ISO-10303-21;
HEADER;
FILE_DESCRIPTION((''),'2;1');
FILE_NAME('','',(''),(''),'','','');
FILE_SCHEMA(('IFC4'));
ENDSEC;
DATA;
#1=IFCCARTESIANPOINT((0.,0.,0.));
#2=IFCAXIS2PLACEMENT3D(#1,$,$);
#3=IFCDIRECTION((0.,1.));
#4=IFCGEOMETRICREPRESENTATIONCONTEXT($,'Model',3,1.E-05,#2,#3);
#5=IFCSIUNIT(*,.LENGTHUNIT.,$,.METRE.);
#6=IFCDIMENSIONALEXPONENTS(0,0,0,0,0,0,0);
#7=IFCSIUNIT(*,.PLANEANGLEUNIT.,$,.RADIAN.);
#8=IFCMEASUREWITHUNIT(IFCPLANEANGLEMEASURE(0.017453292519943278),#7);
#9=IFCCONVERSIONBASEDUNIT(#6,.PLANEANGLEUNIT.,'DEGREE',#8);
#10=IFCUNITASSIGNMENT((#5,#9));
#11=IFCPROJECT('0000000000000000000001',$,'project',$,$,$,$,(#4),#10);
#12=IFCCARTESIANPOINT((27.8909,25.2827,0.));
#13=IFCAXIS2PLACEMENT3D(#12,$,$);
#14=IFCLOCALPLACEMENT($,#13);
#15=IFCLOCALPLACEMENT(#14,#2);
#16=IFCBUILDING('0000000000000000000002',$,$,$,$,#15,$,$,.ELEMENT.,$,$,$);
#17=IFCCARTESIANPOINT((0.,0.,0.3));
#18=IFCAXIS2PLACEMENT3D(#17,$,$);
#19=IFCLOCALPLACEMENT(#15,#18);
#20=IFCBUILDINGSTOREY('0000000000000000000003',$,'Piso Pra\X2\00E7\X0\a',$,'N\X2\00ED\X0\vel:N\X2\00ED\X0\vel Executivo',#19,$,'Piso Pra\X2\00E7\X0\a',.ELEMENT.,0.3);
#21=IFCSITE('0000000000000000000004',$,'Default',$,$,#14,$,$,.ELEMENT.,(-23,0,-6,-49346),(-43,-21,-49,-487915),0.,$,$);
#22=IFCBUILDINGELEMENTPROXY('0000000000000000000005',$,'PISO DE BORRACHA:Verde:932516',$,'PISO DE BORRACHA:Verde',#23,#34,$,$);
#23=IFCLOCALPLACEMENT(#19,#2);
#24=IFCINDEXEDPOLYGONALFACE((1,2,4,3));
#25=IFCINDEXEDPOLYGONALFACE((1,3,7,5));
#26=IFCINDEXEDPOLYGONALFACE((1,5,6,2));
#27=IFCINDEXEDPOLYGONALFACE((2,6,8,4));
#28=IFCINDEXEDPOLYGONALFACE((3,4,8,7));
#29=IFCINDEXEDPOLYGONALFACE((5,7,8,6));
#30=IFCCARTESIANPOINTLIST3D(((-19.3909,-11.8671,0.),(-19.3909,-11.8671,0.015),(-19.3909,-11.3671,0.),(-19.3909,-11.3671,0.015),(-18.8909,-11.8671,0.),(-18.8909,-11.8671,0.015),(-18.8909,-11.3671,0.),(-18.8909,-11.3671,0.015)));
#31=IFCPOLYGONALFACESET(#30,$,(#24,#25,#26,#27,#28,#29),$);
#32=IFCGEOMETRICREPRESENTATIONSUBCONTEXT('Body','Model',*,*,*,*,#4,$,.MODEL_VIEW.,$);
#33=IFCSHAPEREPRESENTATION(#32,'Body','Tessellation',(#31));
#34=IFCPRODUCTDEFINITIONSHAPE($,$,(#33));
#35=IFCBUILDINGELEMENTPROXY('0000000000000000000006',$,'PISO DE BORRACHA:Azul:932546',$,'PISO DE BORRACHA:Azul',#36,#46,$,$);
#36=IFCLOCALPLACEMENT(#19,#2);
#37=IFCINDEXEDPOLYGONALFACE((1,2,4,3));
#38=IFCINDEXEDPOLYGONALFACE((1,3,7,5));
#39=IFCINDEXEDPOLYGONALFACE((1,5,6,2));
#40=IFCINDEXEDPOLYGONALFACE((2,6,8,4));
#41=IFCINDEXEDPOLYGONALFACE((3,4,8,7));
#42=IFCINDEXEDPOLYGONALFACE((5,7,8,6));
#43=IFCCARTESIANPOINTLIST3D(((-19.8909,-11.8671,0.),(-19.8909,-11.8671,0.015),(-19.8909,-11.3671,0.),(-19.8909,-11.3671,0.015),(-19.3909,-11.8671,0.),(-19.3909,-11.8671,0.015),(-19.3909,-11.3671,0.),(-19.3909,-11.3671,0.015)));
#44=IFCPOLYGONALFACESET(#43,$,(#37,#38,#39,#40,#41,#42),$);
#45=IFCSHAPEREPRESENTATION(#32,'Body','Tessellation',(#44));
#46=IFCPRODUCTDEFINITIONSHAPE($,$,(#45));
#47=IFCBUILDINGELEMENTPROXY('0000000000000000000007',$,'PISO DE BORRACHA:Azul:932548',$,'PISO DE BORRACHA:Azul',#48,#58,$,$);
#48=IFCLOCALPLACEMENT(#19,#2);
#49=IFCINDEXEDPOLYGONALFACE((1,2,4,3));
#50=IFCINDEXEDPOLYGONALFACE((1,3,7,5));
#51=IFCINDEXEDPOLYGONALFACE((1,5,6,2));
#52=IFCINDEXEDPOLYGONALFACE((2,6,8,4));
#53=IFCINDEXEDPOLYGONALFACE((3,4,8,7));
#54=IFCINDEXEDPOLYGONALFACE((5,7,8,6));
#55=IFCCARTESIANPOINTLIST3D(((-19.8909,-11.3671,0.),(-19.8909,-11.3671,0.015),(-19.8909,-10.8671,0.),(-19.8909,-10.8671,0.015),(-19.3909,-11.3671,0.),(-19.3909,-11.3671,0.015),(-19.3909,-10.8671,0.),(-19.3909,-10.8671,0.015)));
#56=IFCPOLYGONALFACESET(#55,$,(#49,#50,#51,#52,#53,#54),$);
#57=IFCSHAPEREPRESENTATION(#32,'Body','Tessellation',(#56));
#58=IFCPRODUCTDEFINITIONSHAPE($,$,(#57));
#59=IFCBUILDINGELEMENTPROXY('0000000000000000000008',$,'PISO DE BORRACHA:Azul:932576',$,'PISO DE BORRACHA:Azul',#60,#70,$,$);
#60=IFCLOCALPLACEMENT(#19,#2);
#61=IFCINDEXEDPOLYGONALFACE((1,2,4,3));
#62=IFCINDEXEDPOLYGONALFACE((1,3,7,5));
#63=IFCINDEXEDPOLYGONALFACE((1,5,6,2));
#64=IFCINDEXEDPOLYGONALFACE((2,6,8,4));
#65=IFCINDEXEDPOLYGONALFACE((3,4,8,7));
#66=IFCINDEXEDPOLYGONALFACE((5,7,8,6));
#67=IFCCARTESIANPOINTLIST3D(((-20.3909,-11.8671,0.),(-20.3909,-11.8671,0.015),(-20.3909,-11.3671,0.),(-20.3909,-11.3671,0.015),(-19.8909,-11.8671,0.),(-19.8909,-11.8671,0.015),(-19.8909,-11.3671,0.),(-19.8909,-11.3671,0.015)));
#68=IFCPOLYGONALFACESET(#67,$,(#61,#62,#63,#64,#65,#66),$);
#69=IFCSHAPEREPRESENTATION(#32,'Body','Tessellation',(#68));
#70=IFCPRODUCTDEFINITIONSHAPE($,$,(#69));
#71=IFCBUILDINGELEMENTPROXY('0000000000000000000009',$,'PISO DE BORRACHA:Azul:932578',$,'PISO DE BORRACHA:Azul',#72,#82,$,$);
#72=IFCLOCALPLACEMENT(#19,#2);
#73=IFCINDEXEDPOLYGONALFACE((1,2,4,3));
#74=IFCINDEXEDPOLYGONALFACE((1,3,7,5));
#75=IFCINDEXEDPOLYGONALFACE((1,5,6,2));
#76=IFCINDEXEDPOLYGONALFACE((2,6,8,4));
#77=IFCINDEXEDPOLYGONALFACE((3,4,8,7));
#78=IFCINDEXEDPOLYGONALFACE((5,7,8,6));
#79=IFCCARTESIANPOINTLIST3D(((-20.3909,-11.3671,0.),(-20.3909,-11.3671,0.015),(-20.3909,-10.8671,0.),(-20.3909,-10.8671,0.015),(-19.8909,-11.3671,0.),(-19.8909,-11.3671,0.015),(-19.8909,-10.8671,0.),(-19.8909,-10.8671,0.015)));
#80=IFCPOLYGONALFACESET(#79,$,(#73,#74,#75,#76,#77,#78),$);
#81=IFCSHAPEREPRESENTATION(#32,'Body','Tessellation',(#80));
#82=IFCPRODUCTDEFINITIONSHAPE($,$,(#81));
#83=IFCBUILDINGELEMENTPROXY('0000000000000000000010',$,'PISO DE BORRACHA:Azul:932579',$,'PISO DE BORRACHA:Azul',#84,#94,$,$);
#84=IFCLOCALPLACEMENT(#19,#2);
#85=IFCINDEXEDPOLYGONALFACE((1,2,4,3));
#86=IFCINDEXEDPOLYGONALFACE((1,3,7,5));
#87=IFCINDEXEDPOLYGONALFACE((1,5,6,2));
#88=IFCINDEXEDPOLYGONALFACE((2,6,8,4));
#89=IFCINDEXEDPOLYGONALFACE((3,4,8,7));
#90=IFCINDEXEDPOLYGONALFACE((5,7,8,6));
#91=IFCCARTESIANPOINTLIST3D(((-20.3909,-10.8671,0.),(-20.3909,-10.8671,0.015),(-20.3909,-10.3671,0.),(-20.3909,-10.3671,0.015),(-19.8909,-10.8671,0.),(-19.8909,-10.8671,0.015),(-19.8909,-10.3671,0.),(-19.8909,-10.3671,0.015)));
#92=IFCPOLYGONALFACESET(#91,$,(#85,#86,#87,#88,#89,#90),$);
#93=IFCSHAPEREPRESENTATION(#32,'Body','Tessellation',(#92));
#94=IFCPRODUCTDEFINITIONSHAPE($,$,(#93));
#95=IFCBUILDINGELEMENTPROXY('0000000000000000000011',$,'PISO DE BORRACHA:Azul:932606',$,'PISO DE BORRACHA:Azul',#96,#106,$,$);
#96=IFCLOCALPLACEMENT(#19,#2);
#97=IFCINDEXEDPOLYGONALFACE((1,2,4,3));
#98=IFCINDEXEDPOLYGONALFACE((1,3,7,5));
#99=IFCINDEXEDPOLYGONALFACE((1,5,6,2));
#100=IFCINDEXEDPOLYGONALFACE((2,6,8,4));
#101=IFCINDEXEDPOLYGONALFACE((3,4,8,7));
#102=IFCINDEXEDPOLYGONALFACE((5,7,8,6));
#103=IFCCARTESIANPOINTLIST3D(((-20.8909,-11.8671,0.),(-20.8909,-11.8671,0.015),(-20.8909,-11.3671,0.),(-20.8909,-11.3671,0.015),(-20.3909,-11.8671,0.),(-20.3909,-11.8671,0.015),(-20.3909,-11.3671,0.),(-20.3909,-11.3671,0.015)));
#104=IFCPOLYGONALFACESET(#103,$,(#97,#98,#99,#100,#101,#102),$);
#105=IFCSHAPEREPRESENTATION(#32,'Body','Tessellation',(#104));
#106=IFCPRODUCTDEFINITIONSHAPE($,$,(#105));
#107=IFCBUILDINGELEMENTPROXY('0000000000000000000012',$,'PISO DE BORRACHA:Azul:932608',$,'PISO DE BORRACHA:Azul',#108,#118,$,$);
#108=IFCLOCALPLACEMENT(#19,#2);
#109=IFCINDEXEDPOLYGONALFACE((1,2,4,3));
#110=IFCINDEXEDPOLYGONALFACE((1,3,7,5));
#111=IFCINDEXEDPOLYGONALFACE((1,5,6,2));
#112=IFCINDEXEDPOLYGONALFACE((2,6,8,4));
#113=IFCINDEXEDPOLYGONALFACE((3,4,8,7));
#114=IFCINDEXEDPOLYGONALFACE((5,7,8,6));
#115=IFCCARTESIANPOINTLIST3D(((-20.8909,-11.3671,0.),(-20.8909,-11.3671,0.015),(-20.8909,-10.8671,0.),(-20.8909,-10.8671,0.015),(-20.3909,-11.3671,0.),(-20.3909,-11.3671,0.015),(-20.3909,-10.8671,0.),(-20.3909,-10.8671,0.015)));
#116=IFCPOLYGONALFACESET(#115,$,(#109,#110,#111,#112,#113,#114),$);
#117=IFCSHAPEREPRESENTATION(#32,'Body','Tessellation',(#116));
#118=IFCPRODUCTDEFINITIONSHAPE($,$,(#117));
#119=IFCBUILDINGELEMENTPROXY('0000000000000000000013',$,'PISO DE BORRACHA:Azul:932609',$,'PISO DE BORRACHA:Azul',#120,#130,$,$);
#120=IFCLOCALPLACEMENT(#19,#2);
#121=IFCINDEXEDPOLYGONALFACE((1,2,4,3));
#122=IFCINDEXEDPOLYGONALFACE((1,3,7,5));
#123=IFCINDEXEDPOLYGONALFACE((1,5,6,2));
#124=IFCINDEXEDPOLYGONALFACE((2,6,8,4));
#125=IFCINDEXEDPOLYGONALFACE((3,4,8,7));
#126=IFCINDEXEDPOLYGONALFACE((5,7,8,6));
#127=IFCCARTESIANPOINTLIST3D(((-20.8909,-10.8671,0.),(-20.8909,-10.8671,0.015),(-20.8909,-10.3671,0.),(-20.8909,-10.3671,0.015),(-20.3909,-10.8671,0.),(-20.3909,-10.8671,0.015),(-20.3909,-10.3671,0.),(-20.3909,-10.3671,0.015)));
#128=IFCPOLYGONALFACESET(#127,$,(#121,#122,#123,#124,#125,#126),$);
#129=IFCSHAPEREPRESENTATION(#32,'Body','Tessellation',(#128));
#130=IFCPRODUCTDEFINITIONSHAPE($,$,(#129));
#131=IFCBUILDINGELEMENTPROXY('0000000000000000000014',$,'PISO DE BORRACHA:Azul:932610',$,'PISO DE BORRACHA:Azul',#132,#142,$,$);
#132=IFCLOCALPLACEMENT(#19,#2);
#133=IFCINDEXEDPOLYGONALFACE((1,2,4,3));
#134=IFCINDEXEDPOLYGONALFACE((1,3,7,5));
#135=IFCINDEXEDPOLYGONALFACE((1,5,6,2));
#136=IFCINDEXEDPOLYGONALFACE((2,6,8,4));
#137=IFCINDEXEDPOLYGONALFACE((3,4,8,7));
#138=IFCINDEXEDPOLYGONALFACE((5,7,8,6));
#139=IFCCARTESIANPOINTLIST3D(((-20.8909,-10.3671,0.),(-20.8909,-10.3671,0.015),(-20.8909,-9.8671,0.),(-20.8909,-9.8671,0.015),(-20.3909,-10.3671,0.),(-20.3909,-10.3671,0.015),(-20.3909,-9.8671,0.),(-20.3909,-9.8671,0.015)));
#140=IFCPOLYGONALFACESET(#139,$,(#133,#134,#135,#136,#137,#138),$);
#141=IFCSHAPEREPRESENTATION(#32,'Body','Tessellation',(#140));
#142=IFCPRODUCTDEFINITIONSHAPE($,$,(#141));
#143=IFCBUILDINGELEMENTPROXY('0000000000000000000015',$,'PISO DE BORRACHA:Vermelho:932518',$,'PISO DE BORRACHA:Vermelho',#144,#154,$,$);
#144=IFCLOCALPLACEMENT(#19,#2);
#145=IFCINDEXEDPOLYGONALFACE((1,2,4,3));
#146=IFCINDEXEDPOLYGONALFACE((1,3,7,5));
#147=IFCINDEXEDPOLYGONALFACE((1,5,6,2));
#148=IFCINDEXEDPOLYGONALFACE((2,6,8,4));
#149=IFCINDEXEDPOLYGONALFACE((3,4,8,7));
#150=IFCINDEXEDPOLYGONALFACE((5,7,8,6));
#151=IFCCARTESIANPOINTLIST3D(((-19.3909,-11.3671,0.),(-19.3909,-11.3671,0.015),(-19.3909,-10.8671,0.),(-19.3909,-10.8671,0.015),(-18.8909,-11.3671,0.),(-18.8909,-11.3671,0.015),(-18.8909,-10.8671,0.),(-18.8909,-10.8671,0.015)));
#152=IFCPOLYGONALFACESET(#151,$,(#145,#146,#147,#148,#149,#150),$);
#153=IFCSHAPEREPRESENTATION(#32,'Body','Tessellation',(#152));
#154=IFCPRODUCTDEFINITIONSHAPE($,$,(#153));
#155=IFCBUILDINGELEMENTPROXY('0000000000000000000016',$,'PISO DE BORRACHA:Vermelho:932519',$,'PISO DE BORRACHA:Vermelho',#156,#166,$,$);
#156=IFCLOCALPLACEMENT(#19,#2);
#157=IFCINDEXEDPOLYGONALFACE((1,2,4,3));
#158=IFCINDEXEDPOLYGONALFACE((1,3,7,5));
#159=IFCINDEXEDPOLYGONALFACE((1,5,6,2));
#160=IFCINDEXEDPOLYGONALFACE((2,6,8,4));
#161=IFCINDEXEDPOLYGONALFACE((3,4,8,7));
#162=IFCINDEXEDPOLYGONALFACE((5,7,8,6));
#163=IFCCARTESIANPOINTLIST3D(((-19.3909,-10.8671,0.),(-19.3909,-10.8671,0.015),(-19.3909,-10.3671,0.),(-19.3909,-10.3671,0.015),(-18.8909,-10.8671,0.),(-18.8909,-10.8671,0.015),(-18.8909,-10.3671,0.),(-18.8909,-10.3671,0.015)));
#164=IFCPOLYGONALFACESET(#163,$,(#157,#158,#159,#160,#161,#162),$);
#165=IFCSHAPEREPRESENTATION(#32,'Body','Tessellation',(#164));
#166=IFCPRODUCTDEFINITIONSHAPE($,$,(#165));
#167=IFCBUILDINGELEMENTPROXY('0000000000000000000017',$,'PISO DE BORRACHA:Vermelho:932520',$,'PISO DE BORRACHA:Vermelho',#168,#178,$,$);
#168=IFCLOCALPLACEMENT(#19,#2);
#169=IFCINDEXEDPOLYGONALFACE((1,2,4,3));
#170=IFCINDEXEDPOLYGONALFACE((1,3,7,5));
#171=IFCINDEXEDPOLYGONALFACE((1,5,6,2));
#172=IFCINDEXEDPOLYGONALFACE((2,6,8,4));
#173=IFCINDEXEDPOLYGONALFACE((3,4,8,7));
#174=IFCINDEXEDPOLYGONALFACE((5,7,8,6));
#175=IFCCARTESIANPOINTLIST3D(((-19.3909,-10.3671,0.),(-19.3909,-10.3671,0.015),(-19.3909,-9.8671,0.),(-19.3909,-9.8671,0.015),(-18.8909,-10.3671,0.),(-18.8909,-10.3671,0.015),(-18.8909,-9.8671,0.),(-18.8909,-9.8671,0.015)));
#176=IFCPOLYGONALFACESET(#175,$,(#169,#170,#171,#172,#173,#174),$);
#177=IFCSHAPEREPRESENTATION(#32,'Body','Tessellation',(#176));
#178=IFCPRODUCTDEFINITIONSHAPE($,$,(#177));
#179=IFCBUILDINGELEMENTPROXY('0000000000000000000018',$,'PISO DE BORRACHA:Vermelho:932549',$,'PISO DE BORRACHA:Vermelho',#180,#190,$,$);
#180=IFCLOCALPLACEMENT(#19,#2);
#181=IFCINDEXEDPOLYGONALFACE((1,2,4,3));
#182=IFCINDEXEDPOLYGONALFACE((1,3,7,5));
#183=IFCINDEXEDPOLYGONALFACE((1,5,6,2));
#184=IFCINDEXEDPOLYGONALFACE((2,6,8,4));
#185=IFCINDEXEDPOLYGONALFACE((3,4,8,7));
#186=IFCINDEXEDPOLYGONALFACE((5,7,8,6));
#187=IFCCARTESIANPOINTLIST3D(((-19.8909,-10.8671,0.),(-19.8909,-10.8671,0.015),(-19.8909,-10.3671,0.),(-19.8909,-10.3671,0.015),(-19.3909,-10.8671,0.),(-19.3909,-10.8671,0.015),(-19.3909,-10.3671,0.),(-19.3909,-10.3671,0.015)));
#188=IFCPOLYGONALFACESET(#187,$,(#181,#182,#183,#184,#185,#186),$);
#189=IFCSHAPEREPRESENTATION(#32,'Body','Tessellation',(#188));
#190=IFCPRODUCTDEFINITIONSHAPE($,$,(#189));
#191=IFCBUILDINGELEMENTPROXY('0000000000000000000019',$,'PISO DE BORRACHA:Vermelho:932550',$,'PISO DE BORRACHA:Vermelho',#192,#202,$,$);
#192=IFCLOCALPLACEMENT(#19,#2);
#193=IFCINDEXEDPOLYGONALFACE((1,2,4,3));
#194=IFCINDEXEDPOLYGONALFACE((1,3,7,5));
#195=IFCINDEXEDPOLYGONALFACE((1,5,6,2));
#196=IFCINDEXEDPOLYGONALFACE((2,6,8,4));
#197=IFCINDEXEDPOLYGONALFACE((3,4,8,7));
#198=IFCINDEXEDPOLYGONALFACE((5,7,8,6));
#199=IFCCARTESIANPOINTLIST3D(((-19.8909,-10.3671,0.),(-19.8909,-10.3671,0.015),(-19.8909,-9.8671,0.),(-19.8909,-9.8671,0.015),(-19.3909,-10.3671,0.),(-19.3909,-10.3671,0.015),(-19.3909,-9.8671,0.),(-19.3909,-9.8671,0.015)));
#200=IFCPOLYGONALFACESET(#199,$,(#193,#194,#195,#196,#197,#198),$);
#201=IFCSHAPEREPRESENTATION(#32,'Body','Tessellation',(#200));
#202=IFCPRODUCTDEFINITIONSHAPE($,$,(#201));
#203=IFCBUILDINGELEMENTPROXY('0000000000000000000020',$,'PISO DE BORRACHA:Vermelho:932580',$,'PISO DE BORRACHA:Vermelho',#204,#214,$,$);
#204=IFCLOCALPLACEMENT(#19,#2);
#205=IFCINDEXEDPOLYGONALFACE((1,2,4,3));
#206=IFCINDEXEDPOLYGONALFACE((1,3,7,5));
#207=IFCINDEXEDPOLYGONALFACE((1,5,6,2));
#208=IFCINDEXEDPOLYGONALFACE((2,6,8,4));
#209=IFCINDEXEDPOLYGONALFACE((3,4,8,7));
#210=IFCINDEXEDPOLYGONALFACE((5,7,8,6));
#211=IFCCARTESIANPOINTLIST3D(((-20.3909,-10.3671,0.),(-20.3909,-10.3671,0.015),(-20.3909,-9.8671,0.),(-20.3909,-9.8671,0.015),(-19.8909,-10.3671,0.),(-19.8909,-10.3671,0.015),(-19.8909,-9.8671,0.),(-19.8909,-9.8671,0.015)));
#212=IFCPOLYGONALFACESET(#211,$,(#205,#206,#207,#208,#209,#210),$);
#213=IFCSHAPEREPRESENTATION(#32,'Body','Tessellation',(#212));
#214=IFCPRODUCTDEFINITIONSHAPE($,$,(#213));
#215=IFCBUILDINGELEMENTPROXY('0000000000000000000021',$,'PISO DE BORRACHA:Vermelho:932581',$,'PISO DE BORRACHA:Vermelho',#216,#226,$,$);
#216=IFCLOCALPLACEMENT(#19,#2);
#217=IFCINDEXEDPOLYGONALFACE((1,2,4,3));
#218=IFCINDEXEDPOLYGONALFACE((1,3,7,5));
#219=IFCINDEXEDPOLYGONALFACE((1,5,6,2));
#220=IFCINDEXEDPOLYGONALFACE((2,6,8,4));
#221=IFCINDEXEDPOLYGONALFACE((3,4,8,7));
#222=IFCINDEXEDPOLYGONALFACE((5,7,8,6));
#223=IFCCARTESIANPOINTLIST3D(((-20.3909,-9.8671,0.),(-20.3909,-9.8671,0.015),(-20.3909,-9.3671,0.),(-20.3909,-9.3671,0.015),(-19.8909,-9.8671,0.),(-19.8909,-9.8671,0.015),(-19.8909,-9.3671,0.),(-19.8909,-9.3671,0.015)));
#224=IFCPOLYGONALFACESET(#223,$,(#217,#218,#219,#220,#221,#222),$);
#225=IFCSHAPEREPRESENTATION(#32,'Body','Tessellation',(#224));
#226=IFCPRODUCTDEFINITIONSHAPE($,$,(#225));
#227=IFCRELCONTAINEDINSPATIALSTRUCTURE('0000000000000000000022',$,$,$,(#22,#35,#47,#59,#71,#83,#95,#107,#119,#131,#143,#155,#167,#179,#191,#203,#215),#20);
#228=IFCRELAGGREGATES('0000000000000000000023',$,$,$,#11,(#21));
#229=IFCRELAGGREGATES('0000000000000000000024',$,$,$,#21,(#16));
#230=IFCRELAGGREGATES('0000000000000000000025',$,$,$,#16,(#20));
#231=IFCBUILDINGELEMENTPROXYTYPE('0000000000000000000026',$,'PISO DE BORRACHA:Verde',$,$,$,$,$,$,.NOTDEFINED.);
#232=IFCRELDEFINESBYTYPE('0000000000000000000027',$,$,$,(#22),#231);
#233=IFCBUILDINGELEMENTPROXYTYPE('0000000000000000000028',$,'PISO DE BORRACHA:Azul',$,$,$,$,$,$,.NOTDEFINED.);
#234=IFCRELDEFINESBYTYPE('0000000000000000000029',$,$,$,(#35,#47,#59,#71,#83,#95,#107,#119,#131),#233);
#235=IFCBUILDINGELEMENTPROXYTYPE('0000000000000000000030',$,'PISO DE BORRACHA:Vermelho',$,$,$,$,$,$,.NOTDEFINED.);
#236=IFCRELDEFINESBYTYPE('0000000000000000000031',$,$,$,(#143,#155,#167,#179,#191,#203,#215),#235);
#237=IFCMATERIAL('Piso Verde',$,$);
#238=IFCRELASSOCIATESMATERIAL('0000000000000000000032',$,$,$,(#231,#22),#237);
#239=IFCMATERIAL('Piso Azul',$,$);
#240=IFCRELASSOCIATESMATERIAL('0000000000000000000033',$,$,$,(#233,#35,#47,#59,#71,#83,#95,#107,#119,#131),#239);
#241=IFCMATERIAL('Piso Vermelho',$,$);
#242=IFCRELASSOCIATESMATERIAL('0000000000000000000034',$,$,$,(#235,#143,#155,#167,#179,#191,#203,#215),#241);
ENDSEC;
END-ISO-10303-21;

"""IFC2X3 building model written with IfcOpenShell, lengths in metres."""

from ifc_helpers import new_model, entity, si_unit, converted_unit, direction, frame, origin, origin_2d_with_axis, place, context, subcontext, project, spatial, rectangle, extrude, source, transform, mapped, material, type_object, type_shapes, element, save


model = new_model("IFC2X3")

# Units and contexts
model_context = context("Model", 3, precision=1e-05, world=origin(), true_north=direction((0.0, 1.0)))
body_context = subcontext(model_context, "Body", "Model", "MODEL_VIEW")
ifc_project = project(units=[si_unit("LENGTHUNIT", "METRE"), converted_unit("PLANEANGLEUNIT", "DEGREE", entity("IfcPlaneAngleMeasure", 0.017453292519943278), si_unit("PLANEANGLEUNIT", "RADIAN"), dimensions=[0, 0, 0, 0, 0, 0, 0])], contexts=[model_context])

# Site, building, storey
site_placement = place(None, frame((27.8909, 25.2827, 0.0)))
site = spatial("IfcSite", under=ifc_project, at=site_placement, Name="Default", CompositionType="ELEMENT", RefLatitude=(-23, 0, -6, -49346), RefLongitude=(-43, -21, -49, -487915), RefElevation=0.0)
building_placement = place(site_placement, origin())
building = spatial("IfcBuilding", under=site, at=building_placement, CompositionType="ELEMENT")
storey_placement = place(building_placement, frame((0.0, 0.0, 0.3)))
storey = spatial("IfcBuildingStorey", under=building, at=storey_placement, Name="Piso Praça", ObjectType="Nível:Nível Executivo", LongName="Piso Praça", CompositionType="ELEMENT", Elevation=0.3)

# Building element proxies
ifc_material_1 = material(Name="Piso Verde")
building_element_proxy_type_1 = type_object("IfcBuildingElementProxyType", Name="PISO DE BORRACHA:Verde", PredefinedType="NOTDEFINED", material=ifc_material_1)
shared_shape_1 = source(origin(), body_context, "Body", "SweptSolid", [
    extrude(rectangle(XDim=0.5, YDim=0.5, at=origin_2d_with_axis()), frame((0.25, 0.25, 0.0), z_axis=(0.0, 0.0, 1.0), x_axis=(-1.0, 0.0, 0.0)), (0.0, 0.0, 1.0), 0.015),
])
type_shapes(building_element_proxy_type_1, [shared_shape_1])
proxy_1_placement = place(storey_placement, frame((-19.3909, -11.3671, 0.0), z_axis=(0.0, 0.0, 1.0), x_axis=(0.0, -1.0, 0.0)))
element("IfcBuildingElementProxy", 1, at=proxy_1_placement, inside=storey, type_object=building_element_proxy_type_1, material=ifc_material_1, Name="PISO DE BORRACHA:Verde:932516", ObjectType="PISO DE BORRACHA:Verde", context=body_context, shape_type="MappedRepresentation", body=[
    mapped(shared_shape_1, transform((0.0, 0.0, 0.0), scale=1.0)),
])
ifc_material_2 = material(Name="Piso Azul")
building_element_proxy_type_2 = type_object("IfcBuildingElementProxyType", Name="PISO DE BORRACHA:Azul", PredefinedType="NOTDEFINED", material=ifc_material_2)
shared_shape_2 = source(origin(), body_context, "Body", "SweptSolid", [
    extrude(rectangle(XDim=0.5, YDim=0.5, at=origin_2d_with_axis()), frame((0.25, 0.25, 0.0), z_axis=(0.0, 0.0, 1.0), x_axis=(-1.0, 0.0, 0.0)), (0.0, 0.0, 1.0), 0.015),
])
type_shapes(building_element_proxy_type_2, [shared_shape_2])
for number, where, z_axis, x_axis, name in (
    (2, (-19.8909, -11.3671, 0.0), (0.0, 0.0, 1.0), (0.0, -1.0, 0.0), "PISO DE BORRACHA:Azul:932546"),
    (3, (-19.8909, -10.8671, 0.0), (0.0, 0.0, 1.0), (0.0, -1.0, 0.0), "PISO DE BORRACHA:Azul:932548"),
    (4, (-20.3909, -11.3671, 0.0), (0.0, 0.0, 1.0), (0.0, -1.0, 0.0), "PISO DE BORRACHA:Azul:932576"),
    (5, (-20.3909, -10.8671, 0.0), (0.0, 0.0, 1.0), (0.0, -1.0, 0.0), "PISO DE BORRACHA:Azul:932578"),
    (6, (-20.3909, -10.3671, 0.0), (0.0, 0.0, 1.0), (0.0, -1.0, 0.0), "PISO DE BORRACHA:Azul:932579"),
    (7, (-20.8909, -11.3671, 0.0), (0.0, 0.0, 1.0), (0.0, -1.0, 0.0), "PISO DE BORRACHA:Azul:932606"),
    (8, (-20.8909, -10.8671, 0.0), (0.0, 0.0, 1.0), (0.0, -1.0, 0.0), "PISO DE BORRACHA:Azul:932608"),
    (9, (-20.8909, -10.3671, 0.0), (0.0, 0.0, 1.0), (0.0, -1.0, 0.0), "PISO DE BORRACHA:Azul:932609"),
    (10, (-20.8909, -9.8671, 0.0), (0.0, 0.0, 1.0), (0.0, -1.0, 0.0), "PISO DE BORRACHA:Azul:932610"),
):
    element("IfcBuildingElementProxy", number, at=place(storey_placement, frame(where, z_axis=z_axis, x_axis=x_axis)), inside=storey, type_object=building_element_proxy_type_2, material=ifc_material_2, Name=name, ObjectType="PISO DE BORRACHA:Azul", context=body_context, shape_type="MappedRepresentation", body=[
        mapped(shared_shape_2, transform((0.0, 0.0, 0.0), scale=1.0)),
    ])
ifc_material_3 = material(Name="Piso Vermelho")
building_element_proxy_type_3 = type_object("IfcBuildingElementProxyType", Name="PISO DE BORRACHA:Vermelho", PredefinedType="NOTDEFINED", material=ifc_material_3)
shared_shape_3 = source(origin(), body_context, "Body", "SweptSolid", [
    extrude(rectangle(XDim=0.5, YDim=0.5, at=origin_2d_with_axis()), frame((0.25, 0.25, 0.0), z_axis=(0.0, 0.0, 1.0), x_axis=(-1.0, 0.0, 0.0)), (0.0, 0.0, 1.0), 0.015),
])
type_shapes(building_element_proxy_type_3, [shared_shape_3])
for number, where, z_axis, x_axis, name in (
    (11, (-19.3909, -10.8671, 0.0), (0.0, 0.0, 1.0), (0.0, -1.0, 0.0), "PISO DE BORRACHA:Vermelho:932518"),
    (12, (-19.3909, -10.3671, 0.0), (0.0, 0.0, 1.0), (0.0, -1.0, 0.0), "PISO DE BORRACHA:Vermelho:932519"),
    (13, (-19.3909, -9.8671, 0.0), (0.0, 0.0, 1.0), (0.0, -1.0, 0.0), "PISO DE BORRACHA:Vermelho:932520"),
    (14, (-19.8909, -10.3671, 0.0), (0.0, 0.0, 1.0), (0.0, -1.0, 0.0), "PISO DE BORRACHA:Vermelho:932549"),
    (15, (-19.8909, -9.8671, 0.0), (0.0, 0.0, 1.0), (0.0, -1.0, 0.0), "PISO DE BORRACHA:Vermelho:932550"),
    (16, (-20.3909, -9.8671, 0.0), (0.0, 0.0, 1.0), (0.0, -1.0, 0.0), "PISO DE BORRACHA:Vermelho:932580"),
    (17, (-20.3909, -9.3671, 0.0), (0.0, 0.0, 1.0), (0.0, -1.0, 0.0), "PISO DE BORRACHA:Vermelho:932581"),
):
    element("IfcBuildingElementProxy", number, at=place(storey_placement, frame(where, z_axis=z_axis, x_axis=x_axis)), inside=storey, type_object=building_element_proxy_type_3, material=ifc_material_3, Name=name, ObjectType="PISO DE BORRACHA:Vermelho", context=body_context, shape_type="MappedRepresentation", body=[
        mapped(shared_shape_3, transform((0.0, 0.0, 0.0), scale=1.0)),
    ])

save(model, "model.ifc")
